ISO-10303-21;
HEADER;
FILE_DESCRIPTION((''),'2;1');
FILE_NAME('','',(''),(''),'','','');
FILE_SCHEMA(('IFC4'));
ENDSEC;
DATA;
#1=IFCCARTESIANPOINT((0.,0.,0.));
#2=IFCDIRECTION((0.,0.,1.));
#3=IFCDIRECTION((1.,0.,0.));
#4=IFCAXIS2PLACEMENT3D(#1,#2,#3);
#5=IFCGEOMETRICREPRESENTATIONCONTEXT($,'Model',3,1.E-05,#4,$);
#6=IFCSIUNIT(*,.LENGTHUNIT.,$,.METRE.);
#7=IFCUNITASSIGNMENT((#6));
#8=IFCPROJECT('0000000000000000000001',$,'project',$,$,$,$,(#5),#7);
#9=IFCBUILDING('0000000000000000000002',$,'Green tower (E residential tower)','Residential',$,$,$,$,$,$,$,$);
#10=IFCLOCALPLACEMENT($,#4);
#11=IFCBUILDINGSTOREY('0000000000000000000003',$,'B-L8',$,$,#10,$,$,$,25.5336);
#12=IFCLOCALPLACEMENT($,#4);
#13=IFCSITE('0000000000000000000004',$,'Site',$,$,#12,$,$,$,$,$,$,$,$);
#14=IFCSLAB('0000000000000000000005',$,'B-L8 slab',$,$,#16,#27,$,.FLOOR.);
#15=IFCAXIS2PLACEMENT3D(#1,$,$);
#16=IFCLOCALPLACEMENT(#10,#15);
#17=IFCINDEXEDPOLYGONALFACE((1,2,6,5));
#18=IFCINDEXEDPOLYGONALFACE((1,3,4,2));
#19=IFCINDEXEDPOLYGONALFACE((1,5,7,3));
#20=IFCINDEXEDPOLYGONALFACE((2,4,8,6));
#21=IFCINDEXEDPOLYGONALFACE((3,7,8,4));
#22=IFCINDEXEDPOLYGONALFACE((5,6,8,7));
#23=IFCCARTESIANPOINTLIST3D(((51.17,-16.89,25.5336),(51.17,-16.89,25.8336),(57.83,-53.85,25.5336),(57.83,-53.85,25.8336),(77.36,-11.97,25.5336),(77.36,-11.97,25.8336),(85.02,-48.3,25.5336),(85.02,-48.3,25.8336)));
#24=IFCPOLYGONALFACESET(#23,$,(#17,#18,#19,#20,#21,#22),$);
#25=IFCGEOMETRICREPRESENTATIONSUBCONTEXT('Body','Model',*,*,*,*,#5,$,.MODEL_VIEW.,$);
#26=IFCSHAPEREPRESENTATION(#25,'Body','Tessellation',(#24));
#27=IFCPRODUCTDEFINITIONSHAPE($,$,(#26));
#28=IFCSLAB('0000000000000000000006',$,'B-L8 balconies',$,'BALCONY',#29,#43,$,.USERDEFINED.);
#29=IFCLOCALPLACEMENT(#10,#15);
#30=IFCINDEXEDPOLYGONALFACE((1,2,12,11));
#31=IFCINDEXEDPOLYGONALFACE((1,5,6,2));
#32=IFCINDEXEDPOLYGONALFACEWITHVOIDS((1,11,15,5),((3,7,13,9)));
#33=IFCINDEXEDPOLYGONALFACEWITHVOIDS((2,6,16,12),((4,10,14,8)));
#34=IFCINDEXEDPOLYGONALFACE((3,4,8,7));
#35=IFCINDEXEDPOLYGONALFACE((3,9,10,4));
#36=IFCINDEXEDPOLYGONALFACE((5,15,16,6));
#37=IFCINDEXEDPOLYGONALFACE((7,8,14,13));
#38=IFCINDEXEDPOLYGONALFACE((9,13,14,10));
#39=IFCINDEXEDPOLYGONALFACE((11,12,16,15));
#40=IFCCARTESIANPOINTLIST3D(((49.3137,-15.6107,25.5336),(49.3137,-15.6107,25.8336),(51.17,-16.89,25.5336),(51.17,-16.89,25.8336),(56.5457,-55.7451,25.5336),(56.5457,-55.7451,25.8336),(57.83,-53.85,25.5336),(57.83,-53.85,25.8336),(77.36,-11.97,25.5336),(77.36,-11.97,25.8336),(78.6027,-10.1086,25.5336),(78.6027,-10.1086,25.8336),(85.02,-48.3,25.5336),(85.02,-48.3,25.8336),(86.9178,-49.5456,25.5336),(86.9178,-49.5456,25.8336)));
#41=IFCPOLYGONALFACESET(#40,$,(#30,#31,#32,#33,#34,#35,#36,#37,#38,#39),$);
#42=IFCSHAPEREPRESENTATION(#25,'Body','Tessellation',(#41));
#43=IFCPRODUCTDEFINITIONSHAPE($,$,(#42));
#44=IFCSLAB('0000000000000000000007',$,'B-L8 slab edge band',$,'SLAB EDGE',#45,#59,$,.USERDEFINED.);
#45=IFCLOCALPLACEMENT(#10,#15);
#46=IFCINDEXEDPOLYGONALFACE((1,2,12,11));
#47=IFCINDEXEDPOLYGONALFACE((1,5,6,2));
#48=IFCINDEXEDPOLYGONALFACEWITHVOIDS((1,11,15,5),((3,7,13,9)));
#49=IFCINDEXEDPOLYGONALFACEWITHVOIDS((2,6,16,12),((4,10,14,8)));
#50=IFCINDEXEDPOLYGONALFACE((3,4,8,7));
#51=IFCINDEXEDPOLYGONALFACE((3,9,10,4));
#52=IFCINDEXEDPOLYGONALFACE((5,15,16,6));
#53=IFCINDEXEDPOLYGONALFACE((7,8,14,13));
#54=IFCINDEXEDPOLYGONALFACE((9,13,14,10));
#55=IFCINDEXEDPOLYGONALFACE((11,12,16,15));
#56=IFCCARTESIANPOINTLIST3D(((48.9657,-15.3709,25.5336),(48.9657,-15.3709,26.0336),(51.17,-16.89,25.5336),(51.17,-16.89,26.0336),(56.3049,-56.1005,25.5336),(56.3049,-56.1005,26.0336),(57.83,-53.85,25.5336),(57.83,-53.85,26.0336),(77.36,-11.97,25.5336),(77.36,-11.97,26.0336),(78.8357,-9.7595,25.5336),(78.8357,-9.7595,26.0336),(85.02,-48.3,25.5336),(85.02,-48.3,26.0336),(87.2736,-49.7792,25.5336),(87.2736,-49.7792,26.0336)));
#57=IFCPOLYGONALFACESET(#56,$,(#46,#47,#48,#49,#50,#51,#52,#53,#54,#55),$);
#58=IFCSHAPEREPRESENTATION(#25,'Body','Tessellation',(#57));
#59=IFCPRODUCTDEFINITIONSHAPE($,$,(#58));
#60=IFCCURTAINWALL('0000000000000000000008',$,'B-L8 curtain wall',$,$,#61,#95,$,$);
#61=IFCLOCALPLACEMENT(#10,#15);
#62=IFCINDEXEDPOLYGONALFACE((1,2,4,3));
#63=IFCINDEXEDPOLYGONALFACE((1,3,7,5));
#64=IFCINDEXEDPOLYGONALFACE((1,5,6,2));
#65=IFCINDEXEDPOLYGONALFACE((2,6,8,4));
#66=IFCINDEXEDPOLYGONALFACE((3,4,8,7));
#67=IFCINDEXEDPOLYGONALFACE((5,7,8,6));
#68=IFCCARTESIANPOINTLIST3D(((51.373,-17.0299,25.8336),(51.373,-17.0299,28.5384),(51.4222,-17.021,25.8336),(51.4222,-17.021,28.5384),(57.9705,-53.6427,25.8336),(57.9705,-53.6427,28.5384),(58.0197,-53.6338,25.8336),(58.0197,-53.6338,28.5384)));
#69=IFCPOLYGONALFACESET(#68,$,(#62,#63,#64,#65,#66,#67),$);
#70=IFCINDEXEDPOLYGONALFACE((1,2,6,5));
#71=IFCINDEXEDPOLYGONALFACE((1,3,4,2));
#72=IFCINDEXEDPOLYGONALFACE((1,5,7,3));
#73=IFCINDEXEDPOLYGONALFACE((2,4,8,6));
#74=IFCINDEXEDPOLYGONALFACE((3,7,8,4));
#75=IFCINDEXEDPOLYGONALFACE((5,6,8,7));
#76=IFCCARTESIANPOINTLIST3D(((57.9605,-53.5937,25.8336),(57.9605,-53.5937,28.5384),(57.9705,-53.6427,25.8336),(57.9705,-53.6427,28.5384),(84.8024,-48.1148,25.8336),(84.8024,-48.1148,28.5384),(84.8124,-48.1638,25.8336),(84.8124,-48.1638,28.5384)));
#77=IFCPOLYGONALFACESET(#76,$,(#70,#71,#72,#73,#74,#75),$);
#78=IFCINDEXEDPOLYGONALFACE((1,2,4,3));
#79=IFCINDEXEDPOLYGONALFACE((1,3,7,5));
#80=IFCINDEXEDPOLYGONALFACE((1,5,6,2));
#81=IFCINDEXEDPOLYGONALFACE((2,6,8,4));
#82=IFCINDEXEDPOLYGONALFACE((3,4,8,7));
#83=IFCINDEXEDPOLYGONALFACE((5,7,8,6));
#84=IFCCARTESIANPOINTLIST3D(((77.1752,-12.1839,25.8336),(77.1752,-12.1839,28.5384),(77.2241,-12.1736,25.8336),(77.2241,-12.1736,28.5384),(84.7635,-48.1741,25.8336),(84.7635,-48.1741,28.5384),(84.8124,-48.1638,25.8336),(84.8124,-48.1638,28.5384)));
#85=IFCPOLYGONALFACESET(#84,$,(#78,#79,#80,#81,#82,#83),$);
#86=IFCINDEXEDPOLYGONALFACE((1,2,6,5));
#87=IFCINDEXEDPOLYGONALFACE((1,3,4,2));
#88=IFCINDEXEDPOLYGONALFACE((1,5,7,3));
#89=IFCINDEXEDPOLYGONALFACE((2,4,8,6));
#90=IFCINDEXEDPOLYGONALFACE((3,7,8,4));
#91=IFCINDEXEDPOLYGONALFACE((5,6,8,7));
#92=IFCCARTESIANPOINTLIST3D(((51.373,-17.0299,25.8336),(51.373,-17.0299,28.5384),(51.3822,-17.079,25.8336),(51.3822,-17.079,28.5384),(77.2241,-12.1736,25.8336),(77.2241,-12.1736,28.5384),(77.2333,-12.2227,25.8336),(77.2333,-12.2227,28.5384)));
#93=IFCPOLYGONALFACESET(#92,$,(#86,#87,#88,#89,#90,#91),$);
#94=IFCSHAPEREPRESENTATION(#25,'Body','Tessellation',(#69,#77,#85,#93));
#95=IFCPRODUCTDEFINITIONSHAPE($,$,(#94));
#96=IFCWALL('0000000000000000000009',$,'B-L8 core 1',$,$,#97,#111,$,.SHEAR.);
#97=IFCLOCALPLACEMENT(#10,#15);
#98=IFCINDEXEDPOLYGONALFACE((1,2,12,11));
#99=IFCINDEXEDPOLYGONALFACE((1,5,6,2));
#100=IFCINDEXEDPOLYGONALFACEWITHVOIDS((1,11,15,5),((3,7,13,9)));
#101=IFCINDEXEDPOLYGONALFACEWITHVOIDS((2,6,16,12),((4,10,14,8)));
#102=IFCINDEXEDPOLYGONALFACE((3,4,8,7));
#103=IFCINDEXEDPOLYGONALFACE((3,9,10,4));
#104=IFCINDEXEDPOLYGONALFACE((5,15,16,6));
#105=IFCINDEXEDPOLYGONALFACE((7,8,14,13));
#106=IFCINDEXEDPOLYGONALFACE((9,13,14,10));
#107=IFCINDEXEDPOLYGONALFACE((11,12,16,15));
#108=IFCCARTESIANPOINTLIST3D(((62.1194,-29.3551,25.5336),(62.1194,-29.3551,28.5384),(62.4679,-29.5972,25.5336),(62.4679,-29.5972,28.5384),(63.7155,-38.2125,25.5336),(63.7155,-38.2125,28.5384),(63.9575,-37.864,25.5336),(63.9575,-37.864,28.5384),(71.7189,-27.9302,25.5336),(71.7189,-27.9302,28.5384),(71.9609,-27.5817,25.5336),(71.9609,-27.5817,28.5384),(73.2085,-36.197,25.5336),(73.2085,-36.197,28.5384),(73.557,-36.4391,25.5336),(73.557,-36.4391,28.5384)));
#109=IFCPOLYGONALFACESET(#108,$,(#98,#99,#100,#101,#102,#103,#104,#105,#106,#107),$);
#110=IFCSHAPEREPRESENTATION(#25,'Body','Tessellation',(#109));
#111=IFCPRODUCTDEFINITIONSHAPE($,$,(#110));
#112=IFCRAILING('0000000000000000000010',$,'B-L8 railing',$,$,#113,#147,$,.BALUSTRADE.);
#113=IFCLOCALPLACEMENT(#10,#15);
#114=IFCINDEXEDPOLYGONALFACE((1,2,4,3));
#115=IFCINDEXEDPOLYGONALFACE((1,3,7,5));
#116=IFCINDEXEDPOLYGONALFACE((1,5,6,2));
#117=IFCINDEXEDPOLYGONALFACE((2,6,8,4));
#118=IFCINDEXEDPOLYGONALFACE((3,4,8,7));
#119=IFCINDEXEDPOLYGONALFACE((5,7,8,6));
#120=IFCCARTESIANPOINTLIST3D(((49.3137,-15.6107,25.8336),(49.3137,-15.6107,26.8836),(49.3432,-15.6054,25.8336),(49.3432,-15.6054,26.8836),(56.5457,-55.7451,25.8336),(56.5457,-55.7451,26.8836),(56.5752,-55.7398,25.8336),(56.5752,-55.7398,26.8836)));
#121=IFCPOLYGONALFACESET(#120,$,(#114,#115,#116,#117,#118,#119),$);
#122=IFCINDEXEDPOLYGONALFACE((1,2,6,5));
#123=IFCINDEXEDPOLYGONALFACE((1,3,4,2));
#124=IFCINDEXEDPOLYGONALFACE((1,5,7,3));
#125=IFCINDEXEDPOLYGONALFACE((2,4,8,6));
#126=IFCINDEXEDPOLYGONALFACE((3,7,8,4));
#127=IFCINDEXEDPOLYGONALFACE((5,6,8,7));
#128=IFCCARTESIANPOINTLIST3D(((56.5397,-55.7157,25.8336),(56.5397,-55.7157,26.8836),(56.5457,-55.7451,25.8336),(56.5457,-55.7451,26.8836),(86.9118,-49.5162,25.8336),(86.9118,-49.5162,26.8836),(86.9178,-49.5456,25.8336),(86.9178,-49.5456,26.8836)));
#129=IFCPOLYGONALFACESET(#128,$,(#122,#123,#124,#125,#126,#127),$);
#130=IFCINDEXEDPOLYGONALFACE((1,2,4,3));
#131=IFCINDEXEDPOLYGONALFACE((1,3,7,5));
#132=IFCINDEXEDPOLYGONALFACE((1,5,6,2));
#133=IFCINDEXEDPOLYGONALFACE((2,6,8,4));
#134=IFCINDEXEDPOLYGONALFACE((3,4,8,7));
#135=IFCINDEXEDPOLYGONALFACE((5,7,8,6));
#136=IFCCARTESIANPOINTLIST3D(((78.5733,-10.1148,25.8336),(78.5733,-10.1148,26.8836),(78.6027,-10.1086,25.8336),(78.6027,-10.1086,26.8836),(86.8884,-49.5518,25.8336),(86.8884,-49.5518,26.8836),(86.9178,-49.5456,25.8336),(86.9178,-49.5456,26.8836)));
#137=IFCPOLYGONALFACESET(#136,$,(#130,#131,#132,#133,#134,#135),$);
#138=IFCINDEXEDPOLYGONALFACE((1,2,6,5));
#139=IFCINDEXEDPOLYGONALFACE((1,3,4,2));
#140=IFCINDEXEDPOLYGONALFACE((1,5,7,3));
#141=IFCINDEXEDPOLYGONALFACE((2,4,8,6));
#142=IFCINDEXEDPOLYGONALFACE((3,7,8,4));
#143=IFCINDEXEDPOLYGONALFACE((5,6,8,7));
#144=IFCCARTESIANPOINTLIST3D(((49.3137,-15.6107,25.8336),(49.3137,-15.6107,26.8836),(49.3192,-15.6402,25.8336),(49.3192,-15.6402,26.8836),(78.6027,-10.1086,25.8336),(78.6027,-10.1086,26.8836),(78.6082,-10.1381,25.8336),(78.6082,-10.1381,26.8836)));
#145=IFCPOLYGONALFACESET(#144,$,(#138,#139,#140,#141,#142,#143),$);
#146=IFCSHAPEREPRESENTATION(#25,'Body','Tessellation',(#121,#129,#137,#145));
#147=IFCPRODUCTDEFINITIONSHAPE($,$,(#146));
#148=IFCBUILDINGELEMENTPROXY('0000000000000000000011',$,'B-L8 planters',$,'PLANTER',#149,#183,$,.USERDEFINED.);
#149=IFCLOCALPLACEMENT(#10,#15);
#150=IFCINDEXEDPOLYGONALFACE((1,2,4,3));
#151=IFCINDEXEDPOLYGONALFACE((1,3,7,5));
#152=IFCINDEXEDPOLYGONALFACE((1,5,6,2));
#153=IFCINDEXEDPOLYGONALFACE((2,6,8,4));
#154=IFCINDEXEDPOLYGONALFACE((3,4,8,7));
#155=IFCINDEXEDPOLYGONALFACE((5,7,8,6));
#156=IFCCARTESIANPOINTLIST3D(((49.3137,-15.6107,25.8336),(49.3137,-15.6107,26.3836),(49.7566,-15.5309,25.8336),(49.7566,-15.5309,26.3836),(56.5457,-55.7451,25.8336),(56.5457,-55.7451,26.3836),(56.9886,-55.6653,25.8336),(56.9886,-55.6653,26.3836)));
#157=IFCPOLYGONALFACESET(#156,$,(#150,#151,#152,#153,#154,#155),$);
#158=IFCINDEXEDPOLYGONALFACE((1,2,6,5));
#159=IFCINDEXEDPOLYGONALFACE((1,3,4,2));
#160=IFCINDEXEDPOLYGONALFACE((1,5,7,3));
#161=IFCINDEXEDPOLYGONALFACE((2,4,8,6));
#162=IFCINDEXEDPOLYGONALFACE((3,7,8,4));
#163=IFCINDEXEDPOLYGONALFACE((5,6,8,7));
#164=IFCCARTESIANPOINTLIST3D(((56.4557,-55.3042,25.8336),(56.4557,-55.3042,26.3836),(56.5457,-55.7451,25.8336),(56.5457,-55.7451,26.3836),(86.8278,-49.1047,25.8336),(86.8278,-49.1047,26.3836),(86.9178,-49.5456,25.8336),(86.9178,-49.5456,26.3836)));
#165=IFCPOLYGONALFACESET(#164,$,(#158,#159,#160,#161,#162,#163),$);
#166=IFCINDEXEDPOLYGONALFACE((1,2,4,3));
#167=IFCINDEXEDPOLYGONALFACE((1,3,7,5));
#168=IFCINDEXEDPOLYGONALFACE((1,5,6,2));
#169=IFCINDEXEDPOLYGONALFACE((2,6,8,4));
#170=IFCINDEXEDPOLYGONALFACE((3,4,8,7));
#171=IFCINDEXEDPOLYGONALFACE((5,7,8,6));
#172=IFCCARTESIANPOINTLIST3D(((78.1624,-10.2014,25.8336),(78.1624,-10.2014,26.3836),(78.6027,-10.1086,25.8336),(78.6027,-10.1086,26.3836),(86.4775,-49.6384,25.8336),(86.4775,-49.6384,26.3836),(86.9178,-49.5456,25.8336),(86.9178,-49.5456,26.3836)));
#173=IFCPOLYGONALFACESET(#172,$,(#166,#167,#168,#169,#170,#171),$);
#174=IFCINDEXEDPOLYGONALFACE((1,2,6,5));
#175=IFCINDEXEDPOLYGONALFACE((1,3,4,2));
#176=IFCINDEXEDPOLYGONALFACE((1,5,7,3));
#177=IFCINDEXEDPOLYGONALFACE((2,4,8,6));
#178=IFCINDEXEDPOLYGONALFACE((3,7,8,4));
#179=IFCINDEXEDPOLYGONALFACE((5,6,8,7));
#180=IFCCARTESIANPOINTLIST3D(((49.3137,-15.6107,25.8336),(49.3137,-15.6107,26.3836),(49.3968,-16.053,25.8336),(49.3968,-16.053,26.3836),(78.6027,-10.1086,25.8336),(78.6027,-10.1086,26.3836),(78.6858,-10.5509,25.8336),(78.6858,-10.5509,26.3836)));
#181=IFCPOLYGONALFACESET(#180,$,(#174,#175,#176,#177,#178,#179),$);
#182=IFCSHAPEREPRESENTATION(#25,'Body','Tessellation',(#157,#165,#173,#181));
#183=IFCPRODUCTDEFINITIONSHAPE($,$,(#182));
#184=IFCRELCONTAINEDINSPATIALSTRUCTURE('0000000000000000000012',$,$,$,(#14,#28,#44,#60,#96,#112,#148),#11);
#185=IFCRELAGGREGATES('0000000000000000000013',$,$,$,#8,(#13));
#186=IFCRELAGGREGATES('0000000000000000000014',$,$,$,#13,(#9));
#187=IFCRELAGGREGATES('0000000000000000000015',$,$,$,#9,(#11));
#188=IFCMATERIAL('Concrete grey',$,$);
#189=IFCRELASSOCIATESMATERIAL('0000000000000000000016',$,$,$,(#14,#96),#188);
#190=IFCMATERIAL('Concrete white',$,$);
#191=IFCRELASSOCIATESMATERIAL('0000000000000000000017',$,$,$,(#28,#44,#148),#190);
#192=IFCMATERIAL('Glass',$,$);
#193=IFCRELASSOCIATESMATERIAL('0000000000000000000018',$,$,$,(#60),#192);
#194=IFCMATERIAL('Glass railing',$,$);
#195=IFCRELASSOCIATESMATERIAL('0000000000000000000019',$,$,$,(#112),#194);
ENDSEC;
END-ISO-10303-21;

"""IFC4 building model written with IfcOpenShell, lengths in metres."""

from ifc_helpers import new_model, si_unit, frame, origin_with_axes, place, context, subcontext, project, spatial, polyline, outline, extrude, material, element, save


model = new_model("IFC4")

# Units and contexts
model_context = context("Model", 3, precision=1e-05, world=origin_with_axes())
body_context = subcontext(model_context, "Body", "Model", "MODEL_VIEW")
ifc_project = project(units=[si_unit("LENGTHUNIT", "METRE")], contexts=[model_context])

# Site, building, storey
site_placement = place(None, origin_with_axes())
site = spatial("IfcSite", under=ifc_project, at=site_placement, Name="Site")
building = spatial("IfcBuilding", under=site, Name="Green tower (E residential tower)", Description="Residential")
storey_placement = place(None, origin_with_axes())
storey = spatial("IfcBuildingStorey", under=building, at=storey_placement, Name="B-L8", Elevation=25.5336)

# Slabs
ifc_material_1 = material(Name="Concrete grey")
slab_1_placement = place(storey_placement, origin_with_axes())
element("IfcSlab", 1, at=slab_1_placement, inside=storey, material=ifc_material_1, Name="B-L8 slab", PredefinedType="FLOOR", context=body_context, shape_type="SweptSolid", body=[
    extrude(outline(polyline([(51.17, -16.89), (57.83, -53.85), (85.02, -48.3), (77.36, -11.97), (51.17, -16.89)])), frame((0.0, 0.0, 25.5336), z_axis=(0.0, 0.0, 1.0), x_axis=(1.0, 0.0, 0.0)), (0.0, 0.0, 1.0), 0.3),
])
ifc_material_2 = material(Name="Concrete white")
slab_2_placement = place(storey_placement, origin_with_axes())
element("IfcSlab", 2, at=slab_2_placement, inside=storey, material=ifc_material_2, Name="B-L8 balconies", ObjectType="BALCONY", PredefinedType="USERDEFINED", context=body_context, shape_type="SweptSolid", body=[
    extrude(outline(polyline([(49.3137, -15.6107), (56.5457, -55.7451), (86.9178, -49.5456), (78.6027, -10.1086), (49.3137, -15.6107)]), holes=[polyline([(51.17, -16.89), (57.83, -53.85), (85.02, -48.3), (77.36, -11.97), (51.17, -16.89)])]), frame((0.0, 0.0, 25.5336), z_axis=(0.0, 0.0, 1.0), x_axis=(1.0, 0.0, 0.0)), (0.0, 0.0, 1.0), 0.3),
])
slab_3_placement = place(storey_placement, origin_with_axes())
element("IfcSlab", 3, at=slab_3_placement, inside=storey, material=ifc_material_2, Name="B-L8 slab edge band", ObjectType="SLAB EDGE", PredefinedType="USERDEFINED", context=body_context, shape_type="SweptSolid", body=[
    extrude(outline(polyline([(48.9657, -15.3709), (56.3049, -56.1005), (87.2736, -49.7792), (78.8357, -9.7595), (48.9657, -15.3709)]), holes=[polyline([(51.17, -16.89), (57.83, -53.85), (85.02, -48.3), (77.36, -11.97), (51.17, -16.89)])]), frame((0.0, 0.0, 25.5336), z_axis=(0.0, 0.0, 1.0), x_axis=(1.0, 0.0, 0.0)), (0.0, 0.0, 1.0), 0.5),
])

# Curtain wall
ifc_material_3 = material(Name="Glass")
curtain_wall_placement = place(storey_placement, origin_with_axes())
element("IfcCurtainWall", 4, at=curtain_wall_placement, inside=storey, material=ifc_material_3, Name="B-L8 curtain wall", context=body_context, shape_type="SweptSolid", body=[
    extrude(outline(polyline([(51.373, -17.0299), (57.9705, -53.6427), (58.0197, -53.6338), (51.4222, -17.021), (51.373, -17.0299)])), frame((0.0, 0.0, 25.8336), z_axis=(0.0, 0.0, 1.0), x_axis=(1.0, 0.0, 0.0)), (0.0, 0.0, 1.0), 2.7048),
    extrude(outline(polyline([(57.9705, -53.6427), (84.8124, -48.1638), (84.8024, -48.1148), (57.9605, -53.5937), (57.9705, -53.6427)])), frame((0.0, 0.0, 25.8336), z_axis=(0.0, 0.0, 1.0), x_axis=(1.0, 0.0, 0.0)), (0.0, 0.0, 1.0), 2.7048),
    extrude(outline(polyline([(84.8124, -48.1638), (77.2241, -12.1736), (77.1752, -12.1839), (84.7635, -48.1741), (84.8124, -48.1638)])), frame((0.0, 0.0, 25.8336), z_axis=(0.0, 0.0, 1.0), x_axis=(1.0, 0.0, 0.0)), (0.0, 0.0, 1.0), 2.7048),
    extrude(outline(polyline([(77.2241, -12.1736), (51.373, -17.0299), (51.3822, -17.079), (77.2333, -12.2227), (77.2241, -12.1736)])), frame((0.0, 0.0, 25.8336), z_axis=(0.0, 0.0, 1.0), x_axis=(1.0, 0.0, 0.0)), (0.0, 0.0, 1.0), 2.7048),
])

# Wall
wall_placement = place(storey_placement, origin_with_axes())
element("IfcWall", 5, at=wall_placement, inside=storey, material=ifc_material_1, Name="B-L8 core 1", PredefinedType="SHEAR", context=body_context, shape_type="SweptSolid", body=[
    extrude(outline(polyline([(62.1194, -29.3551), (63.7155, -38.2125), (73.557, -36.4391), (71.9609, -27.5817), (62.1194, -29.3551)]), holes=[polyline([(62.4679, -29.5972), (63.9575, -37.864), (73.2085, -36.197), (71.7189, -27.9302), (62.4679, -29.5972)])]), frame((0.0, 0.0, 25.5336), z_axis=(0.0, 0.0, 1.0), x_axis=(1.0, 0.0, 0.0)), (0.0, 0.0, 1.0), 3.0048),
])

# Railing
ifc_material_4 = material(Name="Glass railing")
railing_placement = place(storey_placement, origin_with_axes())
element("IfcRailing", 6, at=railing_placement, inside=storey, material=ifc_material_4, Name="B-L8 railing", PredefinedType="BALUSTRADE", context=body_context, shape_type="SweptSolid", body=[
    extrude(outline(polyline([(49.3137, -15.6107), (56.5457, -55.7451), (56.5752, -55.7398), (49.3432, -15.6054), (49.3137, -15.6107)])), frame((0.0, 0.0, 25.8336), z_axis=(0.0, 0.0, 1.0), x_axis=(1.0, 0.0, 0.0)), (0.0, 0.0, 1.0), 1.05),
    extrude(outline(polyline([(56.5457, -55.7451), (86.9178, -49.5456), (86.9118, -49.5162), (56.5397, -55.7157), (56.5457, -55.7451)])), frame((0.0, 0.0, 25.8336), z_axis=(0.0, 0.0, 1.0), x_axis=(1.0, 0.0, 0.0)), (0.0, 0.0, 1.0), 1.05),
    extrude(outline(polyline([(86.9178, -49.5456), (78.6027, -10.1086), (78.5733, -10.1148), (86.8884, -49.5518), (86.9178, -49.5456)])), frame((0.0, 0.0, 25.8336), z_axis=(0.0, 0.0, 1.0), x_axis=(1.0, 0.0, 0.0)), (0.0, 0.0, 1.0), 1.05),
    extrude(outline(polyline([(78.6027, -10.1086), (49.3137, -15.6107), (49.3192, -15.6402), (78.6082, -10.1381), (78.6027, -10.1086)])), frame((0.0, 0.0, 25.8336), z_axis=(0.0, 0.0, 1.0), x_axis=(1.0, 0.0, 0.0)), (0.0, 0.0, 1.0), 1.05),
])

# Building element proxy
proxy_1_placement = place(storey_placement, origin_with_axes())
element("IfcBuildingElementProxy", 7, at=proxy_1_placement, inside=storey, material=ifc_material_2, Name="B-L8 planters", ObjectType="PLANTER", PredefinedType="USERDEFINED", context=body_context, shape_type="SweptSolid", body=[
    extrude(outline(polyline([(49.3137, -15.6107), (56.5457, -55.7451), (56.9886, -55.6653), (49.7566, -15.5309), (49.3137, -15.6107)])), frame((0.0, 0.0, 25.8336), z_axis=(0.0, 0.0, 1.0), x_axis=(1.0, 0.0, 0.0)), (0.0, 0.0, 1.0), 0.55),
    extrude(outline(polyline([(56.5457, -55.7451), (86.9178, -49.5456), (86.8278, -49.1047), (56.4557, -55.3042), (56.5457, -55.7451)])), frame((0.0, 0.0, 25.8336), z_axis=(0.0, 0.0, 1.0), x_axis=(1.0, 0.0, 0.0)), (0.0, 0.0, 1.0), 0.55),
    extrude(outline(polyline([(86.9178, -49.5456), (78.6027, -10.1086), (78.1624, -10.2014), (86.4775, -49.6384), (86.9178, -49.5456)])), frame((0.0, 0.0, 25.8336), z_axis=(0.0, 0.0, 1.0), x_axis=(1.0, 0.0, 0.0)), (0.0, 0.0, 1.0), 0.55),
    extrude(outline(polyline([(78.6027, -10.1086), (49.3137, -15.6107), (49.3968, -16.053), (78.6858, -10.5509), (78.6027, -10.1086)])), frame((0.0, 0.0, 25.8336), z_axis=(0.0, 0.0, 1.0), x_axis=(1.0, 0.0, 0.0)), (0.0, 0.0, 1.0), 0.55),
])

save(model, "model.ifc")
